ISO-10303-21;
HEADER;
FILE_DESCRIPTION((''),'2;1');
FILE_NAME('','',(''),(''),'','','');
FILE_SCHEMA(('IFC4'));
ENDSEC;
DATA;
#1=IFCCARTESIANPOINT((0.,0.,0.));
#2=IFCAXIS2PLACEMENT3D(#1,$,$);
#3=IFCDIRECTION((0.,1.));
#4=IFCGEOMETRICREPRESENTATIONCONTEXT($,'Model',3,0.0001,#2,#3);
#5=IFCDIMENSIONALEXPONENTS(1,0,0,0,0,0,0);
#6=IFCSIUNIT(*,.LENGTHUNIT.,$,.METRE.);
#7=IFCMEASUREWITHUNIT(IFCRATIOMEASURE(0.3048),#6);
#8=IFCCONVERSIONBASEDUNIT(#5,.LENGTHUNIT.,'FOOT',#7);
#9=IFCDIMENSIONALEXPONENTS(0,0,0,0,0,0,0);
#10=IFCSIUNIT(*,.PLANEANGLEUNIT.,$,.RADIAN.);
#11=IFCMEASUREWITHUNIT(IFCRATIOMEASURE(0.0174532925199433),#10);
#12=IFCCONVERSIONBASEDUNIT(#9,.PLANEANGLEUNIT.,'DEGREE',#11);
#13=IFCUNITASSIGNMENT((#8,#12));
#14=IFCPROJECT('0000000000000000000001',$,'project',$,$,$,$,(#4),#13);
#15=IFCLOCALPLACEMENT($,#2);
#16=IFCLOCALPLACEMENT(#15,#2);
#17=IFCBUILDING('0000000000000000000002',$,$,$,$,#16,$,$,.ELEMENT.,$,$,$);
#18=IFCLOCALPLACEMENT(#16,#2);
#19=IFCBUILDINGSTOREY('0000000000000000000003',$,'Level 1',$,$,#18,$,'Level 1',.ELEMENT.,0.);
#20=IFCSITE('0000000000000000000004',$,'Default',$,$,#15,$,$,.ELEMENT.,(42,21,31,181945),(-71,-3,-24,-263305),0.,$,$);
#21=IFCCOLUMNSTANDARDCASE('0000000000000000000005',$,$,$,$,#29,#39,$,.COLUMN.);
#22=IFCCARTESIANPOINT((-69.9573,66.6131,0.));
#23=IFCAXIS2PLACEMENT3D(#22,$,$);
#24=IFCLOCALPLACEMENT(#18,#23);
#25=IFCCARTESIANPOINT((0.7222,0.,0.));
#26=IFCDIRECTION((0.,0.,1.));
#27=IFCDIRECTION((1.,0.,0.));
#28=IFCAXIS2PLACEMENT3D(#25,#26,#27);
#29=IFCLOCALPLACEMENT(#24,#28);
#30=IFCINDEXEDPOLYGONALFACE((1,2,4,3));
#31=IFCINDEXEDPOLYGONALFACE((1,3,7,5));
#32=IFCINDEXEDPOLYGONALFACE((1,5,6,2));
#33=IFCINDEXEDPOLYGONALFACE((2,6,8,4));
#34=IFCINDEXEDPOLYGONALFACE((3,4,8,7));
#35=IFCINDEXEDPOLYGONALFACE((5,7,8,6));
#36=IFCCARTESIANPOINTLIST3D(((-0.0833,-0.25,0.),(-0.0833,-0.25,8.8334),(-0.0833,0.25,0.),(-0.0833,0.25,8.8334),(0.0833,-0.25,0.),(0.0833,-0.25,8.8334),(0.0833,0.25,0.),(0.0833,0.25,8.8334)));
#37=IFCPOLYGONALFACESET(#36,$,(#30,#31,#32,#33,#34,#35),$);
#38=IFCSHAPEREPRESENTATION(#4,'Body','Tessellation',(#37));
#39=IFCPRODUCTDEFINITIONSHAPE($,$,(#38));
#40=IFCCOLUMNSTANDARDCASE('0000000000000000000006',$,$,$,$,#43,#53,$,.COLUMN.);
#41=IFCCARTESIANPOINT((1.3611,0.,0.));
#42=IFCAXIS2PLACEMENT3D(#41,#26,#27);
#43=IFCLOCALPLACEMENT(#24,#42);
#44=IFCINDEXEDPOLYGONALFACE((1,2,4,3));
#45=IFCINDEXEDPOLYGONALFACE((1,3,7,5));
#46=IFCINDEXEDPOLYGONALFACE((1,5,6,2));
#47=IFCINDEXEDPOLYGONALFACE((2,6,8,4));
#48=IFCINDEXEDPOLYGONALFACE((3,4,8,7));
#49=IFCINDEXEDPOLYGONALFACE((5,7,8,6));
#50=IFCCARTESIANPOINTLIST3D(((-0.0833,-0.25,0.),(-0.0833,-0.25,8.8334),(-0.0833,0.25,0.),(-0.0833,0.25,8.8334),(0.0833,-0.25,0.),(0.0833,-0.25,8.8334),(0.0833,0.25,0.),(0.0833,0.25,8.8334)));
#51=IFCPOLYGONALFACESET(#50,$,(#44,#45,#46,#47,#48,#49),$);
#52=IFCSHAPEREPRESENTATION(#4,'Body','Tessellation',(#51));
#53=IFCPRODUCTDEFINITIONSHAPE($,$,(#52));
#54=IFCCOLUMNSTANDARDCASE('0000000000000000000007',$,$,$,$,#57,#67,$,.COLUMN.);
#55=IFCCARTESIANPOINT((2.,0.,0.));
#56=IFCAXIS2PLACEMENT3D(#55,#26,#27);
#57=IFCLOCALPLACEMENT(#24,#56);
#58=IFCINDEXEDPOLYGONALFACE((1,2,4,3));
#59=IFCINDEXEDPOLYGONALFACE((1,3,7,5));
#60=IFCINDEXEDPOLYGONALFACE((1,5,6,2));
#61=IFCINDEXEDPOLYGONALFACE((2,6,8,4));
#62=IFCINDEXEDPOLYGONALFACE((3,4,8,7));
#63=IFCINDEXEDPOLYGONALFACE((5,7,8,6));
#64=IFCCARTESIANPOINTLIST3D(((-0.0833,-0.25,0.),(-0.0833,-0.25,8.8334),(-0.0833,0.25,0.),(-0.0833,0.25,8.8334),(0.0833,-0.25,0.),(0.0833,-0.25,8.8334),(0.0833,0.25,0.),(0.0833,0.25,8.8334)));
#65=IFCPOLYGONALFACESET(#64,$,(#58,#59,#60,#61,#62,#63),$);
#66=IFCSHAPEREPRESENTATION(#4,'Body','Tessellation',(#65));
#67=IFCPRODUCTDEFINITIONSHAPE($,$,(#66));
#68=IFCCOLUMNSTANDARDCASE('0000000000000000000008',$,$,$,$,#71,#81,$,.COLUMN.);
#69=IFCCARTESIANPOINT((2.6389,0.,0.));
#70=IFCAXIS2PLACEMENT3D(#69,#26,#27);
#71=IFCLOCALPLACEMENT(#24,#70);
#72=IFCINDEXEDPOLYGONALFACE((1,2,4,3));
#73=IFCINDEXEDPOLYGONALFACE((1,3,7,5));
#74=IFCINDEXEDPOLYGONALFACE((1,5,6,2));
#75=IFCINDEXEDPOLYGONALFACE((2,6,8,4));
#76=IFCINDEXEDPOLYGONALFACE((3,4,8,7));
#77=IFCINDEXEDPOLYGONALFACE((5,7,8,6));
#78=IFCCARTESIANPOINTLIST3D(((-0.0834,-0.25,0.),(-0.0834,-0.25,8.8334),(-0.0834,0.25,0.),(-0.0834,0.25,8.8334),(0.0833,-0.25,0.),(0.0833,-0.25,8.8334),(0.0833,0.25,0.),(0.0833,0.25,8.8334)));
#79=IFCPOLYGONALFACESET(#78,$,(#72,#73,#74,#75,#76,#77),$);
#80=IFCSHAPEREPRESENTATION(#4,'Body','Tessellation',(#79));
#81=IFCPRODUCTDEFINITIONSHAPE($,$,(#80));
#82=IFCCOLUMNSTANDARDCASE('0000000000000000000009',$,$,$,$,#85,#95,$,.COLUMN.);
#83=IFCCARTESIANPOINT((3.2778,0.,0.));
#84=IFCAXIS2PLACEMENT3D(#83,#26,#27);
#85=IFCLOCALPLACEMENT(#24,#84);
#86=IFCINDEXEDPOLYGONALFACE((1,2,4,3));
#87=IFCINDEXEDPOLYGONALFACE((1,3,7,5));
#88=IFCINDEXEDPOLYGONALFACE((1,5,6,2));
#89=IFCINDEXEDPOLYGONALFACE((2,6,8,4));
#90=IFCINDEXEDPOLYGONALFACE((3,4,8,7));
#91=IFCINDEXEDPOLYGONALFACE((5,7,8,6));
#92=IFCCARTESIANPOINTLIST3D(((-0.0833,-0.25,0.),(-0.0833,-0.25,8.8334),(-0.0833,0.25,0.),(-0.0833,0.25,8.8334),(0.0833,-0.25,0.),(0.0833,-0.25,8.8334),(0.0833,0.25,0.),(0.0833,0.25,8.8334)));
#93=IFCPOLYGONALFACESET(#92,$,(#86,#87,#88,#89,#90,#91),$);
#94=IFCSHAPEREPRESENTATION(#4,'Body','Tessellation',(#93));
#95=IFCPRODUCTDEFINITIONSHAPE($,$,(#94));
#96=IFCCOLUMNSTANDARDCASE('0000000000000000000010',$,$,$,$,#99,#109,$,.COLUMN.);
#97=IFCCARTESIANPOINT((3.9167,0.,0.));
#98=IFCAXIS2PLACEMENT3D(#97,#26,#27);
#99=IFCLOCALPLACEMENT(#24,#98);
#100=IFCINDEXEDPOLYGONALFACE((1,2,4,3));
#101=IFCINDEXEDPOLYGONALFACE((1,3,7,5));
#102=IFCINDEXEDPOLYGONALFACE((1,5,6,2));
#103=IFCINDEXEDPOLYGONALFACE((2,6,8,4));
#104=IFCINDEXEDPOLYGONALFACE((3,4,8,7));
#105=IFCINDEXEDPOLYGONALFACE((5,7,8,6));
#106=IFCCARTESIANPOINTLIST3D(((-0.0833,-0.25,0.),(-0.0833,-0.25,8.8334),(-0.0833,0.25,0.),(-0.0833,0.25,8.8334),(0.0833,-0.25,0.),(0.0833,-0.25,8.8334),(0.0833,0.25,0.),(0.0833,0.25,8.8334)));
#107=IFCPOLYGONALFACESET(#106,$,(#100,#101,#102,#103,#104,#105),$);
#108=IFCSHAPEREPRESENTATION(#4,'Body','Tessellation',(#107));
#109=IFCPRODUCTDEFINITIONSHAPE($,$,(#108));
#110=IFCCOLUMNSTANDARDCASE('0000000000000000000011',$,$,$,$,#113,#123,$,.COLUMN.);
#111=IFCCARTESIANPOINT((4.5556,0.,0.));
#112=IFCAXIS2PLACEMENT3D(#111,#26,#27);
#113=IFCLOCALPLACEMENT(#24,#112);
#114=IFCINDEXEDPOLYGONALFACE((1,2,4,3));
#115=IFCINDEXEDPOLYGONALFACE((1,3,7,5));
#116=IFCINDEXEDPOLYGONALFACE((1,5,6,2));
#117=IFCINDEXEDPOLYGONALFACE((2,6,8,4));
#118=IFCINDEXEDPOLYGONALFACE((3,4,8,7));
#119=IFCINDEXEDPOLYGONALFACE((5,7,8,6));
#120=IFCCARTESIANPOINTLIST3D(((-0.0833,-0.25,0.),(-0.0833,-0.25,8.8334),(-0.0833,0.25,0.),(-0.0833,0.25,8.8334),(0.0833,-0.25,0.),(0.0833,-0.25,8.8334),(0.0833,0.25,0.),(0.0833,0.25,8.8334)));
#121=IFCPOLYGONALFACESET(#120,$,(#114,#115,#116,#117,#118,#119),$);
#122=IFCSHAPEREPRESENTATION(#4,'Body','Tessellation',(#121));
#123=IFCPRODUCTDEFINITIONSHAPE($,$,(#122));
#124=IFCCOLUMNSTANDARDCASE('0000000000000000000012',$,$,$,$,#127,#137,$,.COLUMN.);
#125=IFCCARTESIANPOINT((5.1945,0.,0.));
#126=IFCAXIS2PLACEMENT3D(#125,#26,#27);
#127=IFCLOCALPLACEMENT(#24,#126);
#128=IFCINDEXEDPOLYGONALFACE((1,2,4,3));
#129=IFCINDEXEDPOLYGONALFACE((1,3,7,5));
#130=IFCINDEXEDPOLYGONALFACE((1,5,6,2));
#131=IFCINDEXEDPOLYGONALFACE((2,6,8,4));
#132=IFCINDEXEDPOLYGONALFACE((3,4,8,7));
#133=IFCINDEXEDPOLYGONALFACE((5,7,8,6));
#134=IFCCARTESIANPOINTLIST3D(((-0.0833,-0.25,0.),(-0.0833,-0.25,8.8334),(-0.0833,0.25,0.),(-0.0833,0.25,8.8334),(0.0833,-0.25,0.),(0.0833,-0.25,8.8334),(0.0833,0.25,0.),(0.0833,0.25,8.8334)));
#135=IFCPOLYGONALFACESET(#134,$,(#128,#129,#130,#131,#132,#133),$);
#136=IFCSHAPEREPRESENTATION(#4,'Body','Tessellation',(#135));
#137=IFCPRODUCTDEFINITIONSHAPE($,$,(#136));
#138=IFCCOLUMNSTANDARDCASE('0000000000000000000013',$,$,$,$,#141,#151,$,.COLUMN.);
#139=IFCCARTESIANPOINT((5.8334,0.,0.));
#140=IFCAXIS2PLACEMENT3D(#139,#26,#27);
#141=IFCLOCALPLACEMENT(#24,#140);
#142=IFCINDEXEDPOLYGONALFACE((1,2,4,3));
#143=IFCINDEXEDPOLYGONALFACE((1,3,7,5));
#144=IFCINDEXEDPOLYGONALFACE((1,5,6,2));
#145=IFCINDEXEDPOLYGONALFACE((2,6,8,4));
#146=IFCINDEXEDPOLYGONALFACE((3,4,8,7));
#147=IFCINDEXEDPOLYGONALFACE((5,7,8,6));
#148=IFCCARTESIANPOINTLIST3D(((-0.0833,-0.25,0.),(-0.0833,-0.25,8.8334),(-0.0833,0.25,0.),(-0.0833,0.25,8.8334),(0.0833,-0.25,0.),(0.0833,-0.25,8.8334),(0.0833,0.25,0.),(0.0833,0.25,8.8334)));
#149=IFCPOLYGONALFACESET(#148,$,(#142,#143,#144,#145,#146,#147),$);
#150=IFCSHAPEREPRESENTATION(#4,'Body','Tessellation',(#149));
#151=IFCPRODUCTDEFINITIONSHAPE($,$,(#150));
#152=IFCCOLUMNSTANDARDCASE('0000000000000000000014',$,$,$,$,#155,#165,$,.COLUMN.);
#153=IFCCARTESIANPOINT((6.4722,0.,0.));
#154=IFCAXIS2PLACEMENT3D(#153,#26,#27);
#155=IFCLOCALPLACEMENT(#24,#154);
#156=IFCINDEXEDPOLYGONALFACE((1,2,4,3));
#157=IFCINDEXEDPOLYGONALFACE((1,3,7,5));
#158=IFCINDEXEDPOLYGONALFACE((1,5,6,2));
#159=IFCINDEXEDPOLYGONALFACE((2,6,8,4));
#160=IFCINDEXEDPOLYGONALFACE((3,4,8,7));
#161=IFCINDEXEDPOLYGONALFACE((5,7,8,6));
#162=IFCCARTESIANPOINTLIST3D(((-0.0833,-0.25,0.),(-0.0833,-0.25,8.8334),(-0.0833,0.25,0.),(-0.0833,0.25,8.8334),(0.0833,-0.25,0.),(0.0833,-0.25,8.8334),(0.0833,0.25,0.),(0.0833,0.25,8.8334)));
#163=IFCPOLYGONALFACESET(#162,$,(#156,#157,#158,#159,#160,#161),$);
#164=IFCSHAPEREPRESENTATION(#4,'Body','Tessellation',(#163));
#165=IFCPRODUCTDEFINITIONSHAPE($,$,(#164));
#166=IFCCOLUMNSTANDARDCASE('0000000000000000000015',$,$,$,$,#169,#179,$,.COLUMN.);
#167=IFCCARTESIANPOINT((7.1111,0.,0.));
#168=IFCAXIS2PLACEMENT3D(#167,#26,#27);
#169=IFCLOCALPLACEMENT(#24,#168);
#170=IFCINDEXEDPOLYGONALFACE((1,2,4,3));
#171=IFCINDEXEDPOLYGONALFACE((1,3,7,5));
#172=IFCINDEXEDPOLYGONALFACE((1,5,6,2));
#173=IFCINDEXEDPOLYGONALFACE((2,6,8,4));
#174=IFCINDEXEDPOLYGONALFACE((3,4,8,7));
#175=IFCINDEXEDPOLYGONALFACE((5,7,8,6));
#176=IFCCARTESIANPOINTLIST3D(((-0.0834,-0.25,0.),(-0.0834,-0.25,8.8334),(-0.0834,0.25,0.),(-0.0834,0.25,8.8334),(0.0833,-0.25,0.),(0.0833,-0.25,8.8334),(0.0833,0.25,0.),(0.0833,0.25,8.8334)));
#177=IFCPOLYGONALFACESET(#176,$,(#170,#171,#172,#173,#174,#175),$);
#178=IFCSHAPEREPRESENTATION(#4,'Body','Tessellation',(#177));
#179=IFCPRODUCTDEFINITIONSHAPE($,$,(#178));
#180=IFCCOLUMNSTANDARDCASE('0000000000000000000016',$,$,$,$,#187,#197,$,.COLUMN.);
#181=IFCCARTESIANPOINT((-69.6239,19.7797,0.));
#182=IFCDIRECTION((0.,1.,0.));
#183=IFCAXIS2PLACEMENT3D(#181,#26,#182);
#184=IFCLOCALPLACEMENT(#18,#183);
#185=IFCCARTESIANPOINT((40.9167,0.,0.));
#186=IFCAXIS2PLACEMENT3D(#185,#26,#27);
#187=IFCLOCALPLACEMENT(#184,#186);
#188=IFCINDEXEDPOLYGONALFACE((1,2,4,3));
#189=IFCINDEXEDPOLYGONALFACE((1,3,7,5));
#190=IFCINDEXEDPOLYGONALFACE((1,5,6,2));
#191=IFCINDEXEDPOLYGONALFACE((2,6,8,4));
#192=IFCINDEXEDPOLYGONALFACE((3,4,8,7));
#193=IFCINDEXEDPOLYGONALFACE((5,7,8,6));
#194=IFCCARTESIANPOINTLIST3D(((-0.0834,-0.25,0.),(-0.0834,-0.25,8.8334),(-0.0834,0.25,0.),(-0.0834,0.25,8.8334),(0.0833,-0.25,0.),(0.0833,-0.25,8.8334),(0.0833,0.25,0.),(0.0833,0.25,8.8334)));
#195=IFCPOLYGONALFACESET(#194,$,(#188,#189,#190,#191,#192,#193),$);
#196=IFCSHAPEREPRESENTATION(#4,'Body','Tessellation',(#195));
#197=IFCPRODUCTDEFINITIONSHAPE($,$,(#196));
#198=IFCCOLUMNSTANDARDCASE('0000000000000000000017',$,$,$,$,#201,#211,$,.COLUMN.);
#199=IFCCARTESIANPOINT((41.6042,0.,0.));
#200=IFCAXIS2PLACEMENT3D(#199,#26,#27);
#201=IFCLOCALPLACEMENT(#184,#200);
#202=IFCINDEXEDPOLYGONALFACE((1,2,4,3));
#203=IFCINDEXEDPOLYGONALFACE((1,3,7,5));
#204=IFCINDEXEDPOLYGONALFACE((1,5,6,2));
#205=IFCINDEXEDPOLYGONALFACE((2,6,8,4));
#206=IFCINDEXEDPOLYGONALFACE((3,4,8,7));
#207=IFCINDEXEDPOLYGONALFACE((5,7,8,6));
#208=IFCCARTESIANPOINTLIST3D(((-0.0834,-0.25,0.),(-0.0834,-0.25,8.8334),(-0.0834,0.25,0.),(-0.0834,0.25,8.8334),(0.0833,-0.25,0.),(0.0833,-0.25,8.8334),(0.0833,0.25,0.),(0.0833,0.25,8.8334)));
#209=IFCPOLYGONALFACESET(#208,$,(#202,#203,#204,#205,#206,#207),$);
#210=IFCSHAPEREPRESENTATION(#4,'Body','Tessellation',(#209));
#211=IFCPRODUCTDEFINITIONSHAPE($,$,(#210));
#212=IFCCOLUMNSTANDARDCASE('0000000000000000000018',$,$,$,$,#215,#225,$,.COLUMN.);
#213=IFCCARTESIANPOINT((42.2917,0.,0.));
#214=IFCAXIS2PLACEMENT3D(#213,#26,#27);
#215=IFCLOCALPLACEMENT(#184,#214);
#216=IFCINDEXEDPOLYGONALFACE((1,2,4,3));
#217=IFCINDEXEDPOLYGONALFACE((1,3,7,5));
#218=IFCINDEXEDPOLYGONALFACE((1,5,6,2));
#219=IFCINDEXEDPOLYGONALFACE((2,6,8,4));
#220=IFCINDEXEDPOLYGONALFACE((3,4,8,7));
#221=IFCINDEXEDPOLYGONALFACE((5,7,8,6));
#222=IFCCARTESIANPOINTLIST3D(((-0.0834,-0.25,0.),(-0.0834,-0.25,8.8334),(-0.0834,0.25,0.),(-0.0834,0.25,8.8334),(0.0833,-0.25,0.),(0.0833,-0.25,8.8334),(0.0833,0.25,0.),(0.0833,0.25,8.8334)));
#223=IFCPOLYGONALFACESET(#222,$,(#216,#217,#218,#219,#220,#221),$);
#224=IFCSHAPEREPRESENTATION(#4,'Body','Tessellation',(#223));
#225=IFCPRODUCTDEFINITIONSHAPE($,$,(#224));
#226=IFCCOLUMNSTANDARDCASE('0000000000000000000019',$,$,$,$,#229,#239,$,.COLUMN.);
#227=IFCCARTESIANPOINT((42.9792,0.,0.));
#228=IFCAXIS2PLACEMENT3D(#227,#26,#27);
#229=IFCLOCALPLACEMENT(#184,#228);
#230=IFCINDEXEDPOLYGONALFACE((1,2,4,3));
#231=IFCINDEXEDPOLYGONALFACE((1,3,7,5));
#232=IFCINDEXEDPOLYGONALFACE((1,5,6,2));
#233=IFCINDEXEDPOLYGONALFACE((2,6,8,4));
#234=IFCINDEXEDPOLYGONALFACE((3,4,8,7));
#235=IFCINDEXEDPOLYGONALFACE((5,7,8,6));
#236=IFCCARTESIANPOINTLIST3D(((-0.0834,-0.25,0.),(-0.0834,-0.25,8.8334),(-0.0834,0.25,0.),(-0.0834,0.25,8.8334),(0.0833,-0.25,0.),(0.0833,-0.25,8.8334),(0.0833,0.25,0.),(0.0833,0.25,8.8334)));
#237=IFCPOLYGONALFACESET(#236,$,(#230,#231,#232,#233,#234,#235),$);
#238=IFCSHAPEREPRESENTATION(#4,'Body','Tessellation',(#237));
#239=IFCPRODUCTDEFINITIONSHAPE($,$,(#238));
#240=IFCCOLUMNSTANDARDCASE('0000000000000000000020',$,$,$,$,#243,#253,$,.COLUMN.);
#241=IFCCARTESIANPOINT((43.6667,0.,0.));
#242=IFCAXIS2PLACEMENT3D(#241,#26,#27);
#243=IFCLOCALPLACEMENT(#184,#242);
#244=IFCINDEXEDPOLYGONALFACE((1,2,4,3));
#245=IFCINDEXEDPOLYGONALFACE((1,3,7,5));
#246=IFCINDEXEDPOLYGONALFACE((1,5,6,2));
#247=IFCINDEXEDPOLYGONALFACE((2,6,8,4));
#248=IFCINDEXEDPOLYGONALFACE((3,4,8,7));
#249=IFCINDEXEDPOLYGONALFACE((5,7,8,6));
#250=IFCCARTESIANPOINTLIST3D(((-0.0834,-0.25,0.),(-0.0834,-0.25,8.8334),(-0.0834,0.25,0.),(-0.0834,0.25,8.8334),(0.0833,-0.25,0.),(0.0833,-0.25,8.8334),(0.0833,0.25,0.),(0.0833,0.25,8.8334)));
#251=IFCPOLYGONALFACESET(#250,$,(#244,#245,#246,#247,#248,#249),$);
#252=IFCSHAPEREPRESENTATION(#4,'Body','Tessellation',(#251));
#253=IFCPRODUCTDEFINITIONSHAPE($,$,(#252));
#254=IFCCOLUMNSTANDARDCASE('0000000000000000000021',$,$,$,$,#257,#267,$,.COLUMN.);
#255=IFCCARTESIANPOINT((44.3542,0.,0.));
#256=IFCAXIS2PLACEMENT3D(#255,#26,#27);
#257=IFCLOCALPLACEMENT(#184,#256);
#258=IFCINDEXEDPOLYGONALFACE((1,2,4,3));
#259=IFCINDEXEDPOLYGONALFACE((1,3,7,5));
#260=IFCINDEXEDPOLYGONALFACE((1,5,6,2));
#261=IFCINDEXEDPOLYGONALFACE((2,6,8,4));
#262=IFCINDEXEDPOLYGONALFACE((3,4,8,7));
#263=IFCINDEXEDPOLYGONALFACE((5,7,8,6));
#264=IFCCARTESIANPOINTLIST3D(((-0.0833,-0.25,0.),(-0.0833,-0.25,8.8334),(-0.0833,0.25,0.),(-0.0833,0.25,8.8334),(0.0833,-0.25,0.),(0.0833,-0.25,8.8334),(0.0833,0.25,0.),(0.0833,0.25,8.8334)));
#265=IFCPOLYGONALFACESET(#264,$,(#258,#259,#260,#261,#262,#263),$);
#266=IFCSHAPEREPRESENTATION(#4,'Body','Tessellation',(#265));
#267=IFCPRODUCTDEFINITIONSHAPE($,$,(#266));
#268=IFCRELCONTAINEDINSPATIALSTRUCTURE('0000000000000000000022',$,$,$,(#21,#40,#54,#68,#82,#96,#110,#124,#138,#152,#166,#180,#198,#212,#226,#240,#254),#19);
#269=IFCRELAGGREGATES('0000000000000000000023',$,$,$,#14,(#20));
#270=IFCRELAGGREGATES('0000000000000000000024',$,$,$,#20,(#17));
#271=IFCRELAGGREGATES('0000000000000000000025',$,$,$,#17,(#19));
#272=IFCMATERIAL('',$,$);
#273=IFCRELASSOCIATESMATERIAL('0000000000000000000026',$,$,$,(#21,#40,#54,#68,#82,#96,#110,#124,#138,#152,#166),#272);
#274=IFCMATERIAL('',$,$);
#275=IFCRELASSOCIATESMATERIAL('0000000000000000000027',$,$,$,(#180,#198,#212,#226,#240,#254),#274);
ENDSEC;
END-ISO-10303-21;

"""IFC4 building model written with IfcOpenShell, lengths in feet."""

from ifc_helpers import new_model, entity, si_unit, converted_unit, direction, frame, origin, place, context, project, spatial, rectangle, extrude, material, element, save


model = new_model("IFC4")

# Units and contexts
model_context = context("Model", 3, precision=0.0001, world=origin(), true_north=direction((0.0, 1.0)))
ifc_project = project(units=[converted_unit("LENGTHUNIT", "FOOT", entity("IfcRatioMeasure", 0.3048), si_unit("LENGTHUNIT", "METRE"), dimensions=[1, 0, 0, 0, 0, 0, 0]), converted_unit("PLANEANGLEUNIT", "DEGREE", entity("IfcRatioMeasure", 0.0174532925199433), si_unit("PLANEANGLEUNIT", "RADIAN"), dimensions=[0, 0, 0, 0, 0, 0, 0])], contexts=[model_context])

# Site, building, storey
site_placement = place(None, origin())
site = spatial("IfcSite", under=ifc_project, at=site_placement, Name="Default", CompositionType="ELEMENT", RefLatitude=(42, 21, 31, 181945), RefLongitude=(-71, -3, -24, -263305), RefElevation=0.0)
building_placement = place(site_placement, origin())
building = spatial("IfcBuilding", under=site, at=building_placement, CompositionType="ELEMENT")
storey_placement = place(building_placement, origin())
storey = spatial("IfcBuildingStorey", under=building, at=storey_placement, Name="Level 1", LongName="Level 1", CompositionType="ELEMENT", Elevation=0.0)

# Columns
ifc_material_1 = material(Name="")
placement_1 = place(storey_placement, frame((-69.9573, 66.6131, 0.0)))
for number, where, z_axis, x_axis in (
    (1, (0.7222, 0.0, 0.0), (0.0, 0.0, 1.0), (1.0, 0.0, 0.0)),
    (2, (1.3611, 0.0, 0.0), (0.0, 0.0, 1.0), (1.0, 0.0, 0.0)),
    (3, (2.0, 0.0, 0.0), (0.0, 0.0, 1.0), (1.0, 0.0, 0.0)),
    (4, (2.6389, 0.0, 0.0), (0.0, 0.0, 1.0), (1.0, 0.0, 0.0)),
    (5, (3.2778, 0.0, 0.0), (0.0, 0.0, 1.0), (1.0, 0.0, 0.0)),
    (6, (3.9167, 0.0, 0.0), (0.0, 0.0, 1.0), (1.0, 0.0, 0.0)),
    (7, (4.5556, 0.0, 0.0), (0.0, 0.0, 1.0), (1.0, 0.0, 0.0)),
    (8, (5.1945, 0.0, 0.0), (0.0, 0.0, 1.0), (1.0, 0.0, 0.0)),
    (9, (5.8334, 0.0, 0.0), (0.0, 0.0, 1.0), (1.0, 0.0, 0.0)),
    (10, (6.4722, 0.0, 0.0), (0.0, 0.0, 1.0), (1.0, 0.0, 0.0)),
    (11, (7.1111, 0.0, 0.0), (0.0, 0.0, 1.0), (1.0, 0.0, 0.0)),
):
    element("IfcColumnStandardCase", number, at=place(placement_1, frame(where, z_axis=z_axis, x_axis=x_axis)), inside=storey, material=ifc_material_1, PredefinedType="COLUMN", context=model_context, shape_type="SweptSolid", body=[
        extrude(rectangle(XDim=0.1667, YDim=0.5), origin(), (0.0, 0.0, 1.0), 8.8334),
    ])
ifc_material_2 = material(Name="")
placement_2 = place(storey_placement, frame((-69.6239, 19.7797, 0.0), z_axis=(0.0, 0.0, 1.0), x_axis=(0.0, 1.0, 0.0)))
for number, where, z_axis, x_axis in (
    (12, (40.9167, 0.0, 0.0), (0.0, 0.0, 1.0), (1.0, 0.0, 0.0)),
    (13, (41.6042, 0.0, 0.0), (0.0, 0.0, 1.0), (1.0, 0.0, 0.0)),
    (14, (42.2917, 0.0, 0.0), (0.0, 0.0, 1.0), (1.0, 0.0, 0.0)),
    (15, (42.9792, 0.0, 0.0), (0.0, 0.0, 1.0), (1.0, 0.0, 0.0)),
    (16, (43.6667, 0.0, 0.0), (0.0, 0.0, 1.0), (1.0, 0.0, 0.0)),
    (17, (44.3542, 0.0, 0.0), (0.0, 0.0, 1.0), (1.0, 0.0, 0.0)),
):
    element("IfcColumnStandardCase", number, at=place(placement_2, frame(where, z_axis=z_axis, x_axis=x_axis)), inside=storey, material=ifc_material_2, PredefinedType="COLUMN", context=model_context, shape_type="SweptSolid", body=[
        extrude(rectangle(XDim=0.1667, YDim=0.5), origin(), (0.0, 0.0, 1.0), 8.8334),
    ])

save(model, "model.ifc")
